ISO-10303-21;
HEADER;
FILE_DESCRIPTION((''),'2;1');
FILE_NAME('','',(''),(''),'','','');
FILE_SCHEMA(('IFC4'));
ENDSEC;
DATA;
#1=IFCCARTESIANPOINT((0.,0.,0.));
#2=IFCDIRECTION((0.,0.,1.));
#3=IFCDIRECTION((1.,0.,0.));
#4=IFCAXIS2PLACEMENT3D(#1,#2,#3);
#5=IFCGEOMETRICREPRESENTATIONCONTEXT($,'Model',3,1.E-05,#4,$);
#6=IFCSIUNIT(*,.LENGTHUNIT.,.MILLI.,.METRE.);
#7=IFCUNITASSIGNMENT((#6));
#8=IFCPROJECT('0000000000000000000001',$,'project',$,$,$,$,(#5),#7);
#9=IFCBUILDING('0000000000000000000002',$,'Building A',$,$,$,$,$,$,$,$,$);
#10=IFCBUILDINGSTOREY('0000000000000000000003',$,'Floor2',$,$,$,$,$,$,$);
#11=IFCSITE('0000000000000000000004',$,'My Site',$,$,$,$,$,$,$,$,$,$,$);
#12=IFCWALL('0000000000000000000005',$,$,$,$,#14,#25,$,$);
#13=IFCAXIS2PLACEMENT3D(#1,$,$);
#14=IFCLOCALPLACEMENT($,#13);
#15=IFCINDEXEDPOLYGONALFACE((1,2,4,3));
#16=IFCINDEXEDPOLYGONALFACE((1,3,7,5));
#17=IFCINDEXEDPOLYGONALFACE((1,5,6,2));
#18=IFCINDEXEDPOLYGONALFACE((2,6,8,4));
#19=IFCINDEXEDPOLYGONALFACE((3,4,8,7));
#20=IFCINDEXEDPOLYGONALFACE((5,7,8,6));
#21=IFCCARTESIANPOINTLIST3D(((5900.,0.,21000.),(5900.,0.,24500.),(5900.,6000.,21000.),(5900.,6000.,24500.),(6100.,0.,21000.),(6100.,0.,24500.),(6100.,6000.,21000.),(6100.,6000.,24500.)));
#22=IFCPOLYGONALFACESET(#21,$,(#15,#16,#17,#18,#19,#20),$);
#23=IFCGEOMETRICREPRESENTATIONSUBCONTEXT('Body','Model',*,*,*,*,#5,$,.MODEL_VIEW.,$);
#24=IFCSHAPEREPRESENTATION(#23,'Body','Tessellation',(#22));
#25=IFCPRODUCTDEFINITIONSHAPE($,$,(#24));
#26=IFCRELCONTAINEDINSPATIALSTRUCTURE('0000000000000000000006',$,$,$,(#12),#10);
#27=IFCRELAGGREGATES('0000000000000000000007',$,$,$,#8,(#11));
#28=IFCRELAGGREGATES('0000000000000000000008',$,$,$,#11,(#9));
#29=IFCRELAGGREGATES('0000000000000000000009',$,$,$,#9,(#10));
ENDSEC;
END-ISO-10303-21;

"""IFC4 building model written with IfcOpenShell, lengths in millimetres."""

from ifc_helpers import new_model, si_unit, frame, origin_with_axes, place, context, subcontext, project, spatial, indexed_curve, outline, extrude, element, save


model = new_model("IFC4")

# Units and contexts
model_context = context("Model", 3, precision=1e-05, world=origin_with_axes())
body_context = subcontext(model_context, "Body", "Model", "MODEL_VIEW")
ifc_project = project(units=[si_unit("LENGTHUNIT", "METRE", prefix="MILLI")], contexts=[model_context])

# Site, building, storey
site = spatial("IfcSite", under=ifc_project, Name="My Site")
building = spatial("IfcBuilding", under=site, Name="Building A")
storey = spatial("IfcBuildingStorey", under=building, Name="Floor2")

# Wall
wall_placement = place(None, frame((6100.0, 0.0, 21000.0), z_axis=(0.0, 0.0, 1.0), x_axis=(0.0, 1.0, 0.0)))
element("IfcWall", 1, at=wall_placement, inside=storey, context=body_context, shape_type="SweptSolid", body=[
    extrude(outline(indexed_curve([(0.0, 0.0), (0.0, 200.0), (6000.0, 200.0), (6000.0, 0.0), (0.0, 0.0)], self_intersect=False)), origin_with_axes(), (0.0, 0.0, 1.0), 3500.0),
])

save(model, "model.ifc")
